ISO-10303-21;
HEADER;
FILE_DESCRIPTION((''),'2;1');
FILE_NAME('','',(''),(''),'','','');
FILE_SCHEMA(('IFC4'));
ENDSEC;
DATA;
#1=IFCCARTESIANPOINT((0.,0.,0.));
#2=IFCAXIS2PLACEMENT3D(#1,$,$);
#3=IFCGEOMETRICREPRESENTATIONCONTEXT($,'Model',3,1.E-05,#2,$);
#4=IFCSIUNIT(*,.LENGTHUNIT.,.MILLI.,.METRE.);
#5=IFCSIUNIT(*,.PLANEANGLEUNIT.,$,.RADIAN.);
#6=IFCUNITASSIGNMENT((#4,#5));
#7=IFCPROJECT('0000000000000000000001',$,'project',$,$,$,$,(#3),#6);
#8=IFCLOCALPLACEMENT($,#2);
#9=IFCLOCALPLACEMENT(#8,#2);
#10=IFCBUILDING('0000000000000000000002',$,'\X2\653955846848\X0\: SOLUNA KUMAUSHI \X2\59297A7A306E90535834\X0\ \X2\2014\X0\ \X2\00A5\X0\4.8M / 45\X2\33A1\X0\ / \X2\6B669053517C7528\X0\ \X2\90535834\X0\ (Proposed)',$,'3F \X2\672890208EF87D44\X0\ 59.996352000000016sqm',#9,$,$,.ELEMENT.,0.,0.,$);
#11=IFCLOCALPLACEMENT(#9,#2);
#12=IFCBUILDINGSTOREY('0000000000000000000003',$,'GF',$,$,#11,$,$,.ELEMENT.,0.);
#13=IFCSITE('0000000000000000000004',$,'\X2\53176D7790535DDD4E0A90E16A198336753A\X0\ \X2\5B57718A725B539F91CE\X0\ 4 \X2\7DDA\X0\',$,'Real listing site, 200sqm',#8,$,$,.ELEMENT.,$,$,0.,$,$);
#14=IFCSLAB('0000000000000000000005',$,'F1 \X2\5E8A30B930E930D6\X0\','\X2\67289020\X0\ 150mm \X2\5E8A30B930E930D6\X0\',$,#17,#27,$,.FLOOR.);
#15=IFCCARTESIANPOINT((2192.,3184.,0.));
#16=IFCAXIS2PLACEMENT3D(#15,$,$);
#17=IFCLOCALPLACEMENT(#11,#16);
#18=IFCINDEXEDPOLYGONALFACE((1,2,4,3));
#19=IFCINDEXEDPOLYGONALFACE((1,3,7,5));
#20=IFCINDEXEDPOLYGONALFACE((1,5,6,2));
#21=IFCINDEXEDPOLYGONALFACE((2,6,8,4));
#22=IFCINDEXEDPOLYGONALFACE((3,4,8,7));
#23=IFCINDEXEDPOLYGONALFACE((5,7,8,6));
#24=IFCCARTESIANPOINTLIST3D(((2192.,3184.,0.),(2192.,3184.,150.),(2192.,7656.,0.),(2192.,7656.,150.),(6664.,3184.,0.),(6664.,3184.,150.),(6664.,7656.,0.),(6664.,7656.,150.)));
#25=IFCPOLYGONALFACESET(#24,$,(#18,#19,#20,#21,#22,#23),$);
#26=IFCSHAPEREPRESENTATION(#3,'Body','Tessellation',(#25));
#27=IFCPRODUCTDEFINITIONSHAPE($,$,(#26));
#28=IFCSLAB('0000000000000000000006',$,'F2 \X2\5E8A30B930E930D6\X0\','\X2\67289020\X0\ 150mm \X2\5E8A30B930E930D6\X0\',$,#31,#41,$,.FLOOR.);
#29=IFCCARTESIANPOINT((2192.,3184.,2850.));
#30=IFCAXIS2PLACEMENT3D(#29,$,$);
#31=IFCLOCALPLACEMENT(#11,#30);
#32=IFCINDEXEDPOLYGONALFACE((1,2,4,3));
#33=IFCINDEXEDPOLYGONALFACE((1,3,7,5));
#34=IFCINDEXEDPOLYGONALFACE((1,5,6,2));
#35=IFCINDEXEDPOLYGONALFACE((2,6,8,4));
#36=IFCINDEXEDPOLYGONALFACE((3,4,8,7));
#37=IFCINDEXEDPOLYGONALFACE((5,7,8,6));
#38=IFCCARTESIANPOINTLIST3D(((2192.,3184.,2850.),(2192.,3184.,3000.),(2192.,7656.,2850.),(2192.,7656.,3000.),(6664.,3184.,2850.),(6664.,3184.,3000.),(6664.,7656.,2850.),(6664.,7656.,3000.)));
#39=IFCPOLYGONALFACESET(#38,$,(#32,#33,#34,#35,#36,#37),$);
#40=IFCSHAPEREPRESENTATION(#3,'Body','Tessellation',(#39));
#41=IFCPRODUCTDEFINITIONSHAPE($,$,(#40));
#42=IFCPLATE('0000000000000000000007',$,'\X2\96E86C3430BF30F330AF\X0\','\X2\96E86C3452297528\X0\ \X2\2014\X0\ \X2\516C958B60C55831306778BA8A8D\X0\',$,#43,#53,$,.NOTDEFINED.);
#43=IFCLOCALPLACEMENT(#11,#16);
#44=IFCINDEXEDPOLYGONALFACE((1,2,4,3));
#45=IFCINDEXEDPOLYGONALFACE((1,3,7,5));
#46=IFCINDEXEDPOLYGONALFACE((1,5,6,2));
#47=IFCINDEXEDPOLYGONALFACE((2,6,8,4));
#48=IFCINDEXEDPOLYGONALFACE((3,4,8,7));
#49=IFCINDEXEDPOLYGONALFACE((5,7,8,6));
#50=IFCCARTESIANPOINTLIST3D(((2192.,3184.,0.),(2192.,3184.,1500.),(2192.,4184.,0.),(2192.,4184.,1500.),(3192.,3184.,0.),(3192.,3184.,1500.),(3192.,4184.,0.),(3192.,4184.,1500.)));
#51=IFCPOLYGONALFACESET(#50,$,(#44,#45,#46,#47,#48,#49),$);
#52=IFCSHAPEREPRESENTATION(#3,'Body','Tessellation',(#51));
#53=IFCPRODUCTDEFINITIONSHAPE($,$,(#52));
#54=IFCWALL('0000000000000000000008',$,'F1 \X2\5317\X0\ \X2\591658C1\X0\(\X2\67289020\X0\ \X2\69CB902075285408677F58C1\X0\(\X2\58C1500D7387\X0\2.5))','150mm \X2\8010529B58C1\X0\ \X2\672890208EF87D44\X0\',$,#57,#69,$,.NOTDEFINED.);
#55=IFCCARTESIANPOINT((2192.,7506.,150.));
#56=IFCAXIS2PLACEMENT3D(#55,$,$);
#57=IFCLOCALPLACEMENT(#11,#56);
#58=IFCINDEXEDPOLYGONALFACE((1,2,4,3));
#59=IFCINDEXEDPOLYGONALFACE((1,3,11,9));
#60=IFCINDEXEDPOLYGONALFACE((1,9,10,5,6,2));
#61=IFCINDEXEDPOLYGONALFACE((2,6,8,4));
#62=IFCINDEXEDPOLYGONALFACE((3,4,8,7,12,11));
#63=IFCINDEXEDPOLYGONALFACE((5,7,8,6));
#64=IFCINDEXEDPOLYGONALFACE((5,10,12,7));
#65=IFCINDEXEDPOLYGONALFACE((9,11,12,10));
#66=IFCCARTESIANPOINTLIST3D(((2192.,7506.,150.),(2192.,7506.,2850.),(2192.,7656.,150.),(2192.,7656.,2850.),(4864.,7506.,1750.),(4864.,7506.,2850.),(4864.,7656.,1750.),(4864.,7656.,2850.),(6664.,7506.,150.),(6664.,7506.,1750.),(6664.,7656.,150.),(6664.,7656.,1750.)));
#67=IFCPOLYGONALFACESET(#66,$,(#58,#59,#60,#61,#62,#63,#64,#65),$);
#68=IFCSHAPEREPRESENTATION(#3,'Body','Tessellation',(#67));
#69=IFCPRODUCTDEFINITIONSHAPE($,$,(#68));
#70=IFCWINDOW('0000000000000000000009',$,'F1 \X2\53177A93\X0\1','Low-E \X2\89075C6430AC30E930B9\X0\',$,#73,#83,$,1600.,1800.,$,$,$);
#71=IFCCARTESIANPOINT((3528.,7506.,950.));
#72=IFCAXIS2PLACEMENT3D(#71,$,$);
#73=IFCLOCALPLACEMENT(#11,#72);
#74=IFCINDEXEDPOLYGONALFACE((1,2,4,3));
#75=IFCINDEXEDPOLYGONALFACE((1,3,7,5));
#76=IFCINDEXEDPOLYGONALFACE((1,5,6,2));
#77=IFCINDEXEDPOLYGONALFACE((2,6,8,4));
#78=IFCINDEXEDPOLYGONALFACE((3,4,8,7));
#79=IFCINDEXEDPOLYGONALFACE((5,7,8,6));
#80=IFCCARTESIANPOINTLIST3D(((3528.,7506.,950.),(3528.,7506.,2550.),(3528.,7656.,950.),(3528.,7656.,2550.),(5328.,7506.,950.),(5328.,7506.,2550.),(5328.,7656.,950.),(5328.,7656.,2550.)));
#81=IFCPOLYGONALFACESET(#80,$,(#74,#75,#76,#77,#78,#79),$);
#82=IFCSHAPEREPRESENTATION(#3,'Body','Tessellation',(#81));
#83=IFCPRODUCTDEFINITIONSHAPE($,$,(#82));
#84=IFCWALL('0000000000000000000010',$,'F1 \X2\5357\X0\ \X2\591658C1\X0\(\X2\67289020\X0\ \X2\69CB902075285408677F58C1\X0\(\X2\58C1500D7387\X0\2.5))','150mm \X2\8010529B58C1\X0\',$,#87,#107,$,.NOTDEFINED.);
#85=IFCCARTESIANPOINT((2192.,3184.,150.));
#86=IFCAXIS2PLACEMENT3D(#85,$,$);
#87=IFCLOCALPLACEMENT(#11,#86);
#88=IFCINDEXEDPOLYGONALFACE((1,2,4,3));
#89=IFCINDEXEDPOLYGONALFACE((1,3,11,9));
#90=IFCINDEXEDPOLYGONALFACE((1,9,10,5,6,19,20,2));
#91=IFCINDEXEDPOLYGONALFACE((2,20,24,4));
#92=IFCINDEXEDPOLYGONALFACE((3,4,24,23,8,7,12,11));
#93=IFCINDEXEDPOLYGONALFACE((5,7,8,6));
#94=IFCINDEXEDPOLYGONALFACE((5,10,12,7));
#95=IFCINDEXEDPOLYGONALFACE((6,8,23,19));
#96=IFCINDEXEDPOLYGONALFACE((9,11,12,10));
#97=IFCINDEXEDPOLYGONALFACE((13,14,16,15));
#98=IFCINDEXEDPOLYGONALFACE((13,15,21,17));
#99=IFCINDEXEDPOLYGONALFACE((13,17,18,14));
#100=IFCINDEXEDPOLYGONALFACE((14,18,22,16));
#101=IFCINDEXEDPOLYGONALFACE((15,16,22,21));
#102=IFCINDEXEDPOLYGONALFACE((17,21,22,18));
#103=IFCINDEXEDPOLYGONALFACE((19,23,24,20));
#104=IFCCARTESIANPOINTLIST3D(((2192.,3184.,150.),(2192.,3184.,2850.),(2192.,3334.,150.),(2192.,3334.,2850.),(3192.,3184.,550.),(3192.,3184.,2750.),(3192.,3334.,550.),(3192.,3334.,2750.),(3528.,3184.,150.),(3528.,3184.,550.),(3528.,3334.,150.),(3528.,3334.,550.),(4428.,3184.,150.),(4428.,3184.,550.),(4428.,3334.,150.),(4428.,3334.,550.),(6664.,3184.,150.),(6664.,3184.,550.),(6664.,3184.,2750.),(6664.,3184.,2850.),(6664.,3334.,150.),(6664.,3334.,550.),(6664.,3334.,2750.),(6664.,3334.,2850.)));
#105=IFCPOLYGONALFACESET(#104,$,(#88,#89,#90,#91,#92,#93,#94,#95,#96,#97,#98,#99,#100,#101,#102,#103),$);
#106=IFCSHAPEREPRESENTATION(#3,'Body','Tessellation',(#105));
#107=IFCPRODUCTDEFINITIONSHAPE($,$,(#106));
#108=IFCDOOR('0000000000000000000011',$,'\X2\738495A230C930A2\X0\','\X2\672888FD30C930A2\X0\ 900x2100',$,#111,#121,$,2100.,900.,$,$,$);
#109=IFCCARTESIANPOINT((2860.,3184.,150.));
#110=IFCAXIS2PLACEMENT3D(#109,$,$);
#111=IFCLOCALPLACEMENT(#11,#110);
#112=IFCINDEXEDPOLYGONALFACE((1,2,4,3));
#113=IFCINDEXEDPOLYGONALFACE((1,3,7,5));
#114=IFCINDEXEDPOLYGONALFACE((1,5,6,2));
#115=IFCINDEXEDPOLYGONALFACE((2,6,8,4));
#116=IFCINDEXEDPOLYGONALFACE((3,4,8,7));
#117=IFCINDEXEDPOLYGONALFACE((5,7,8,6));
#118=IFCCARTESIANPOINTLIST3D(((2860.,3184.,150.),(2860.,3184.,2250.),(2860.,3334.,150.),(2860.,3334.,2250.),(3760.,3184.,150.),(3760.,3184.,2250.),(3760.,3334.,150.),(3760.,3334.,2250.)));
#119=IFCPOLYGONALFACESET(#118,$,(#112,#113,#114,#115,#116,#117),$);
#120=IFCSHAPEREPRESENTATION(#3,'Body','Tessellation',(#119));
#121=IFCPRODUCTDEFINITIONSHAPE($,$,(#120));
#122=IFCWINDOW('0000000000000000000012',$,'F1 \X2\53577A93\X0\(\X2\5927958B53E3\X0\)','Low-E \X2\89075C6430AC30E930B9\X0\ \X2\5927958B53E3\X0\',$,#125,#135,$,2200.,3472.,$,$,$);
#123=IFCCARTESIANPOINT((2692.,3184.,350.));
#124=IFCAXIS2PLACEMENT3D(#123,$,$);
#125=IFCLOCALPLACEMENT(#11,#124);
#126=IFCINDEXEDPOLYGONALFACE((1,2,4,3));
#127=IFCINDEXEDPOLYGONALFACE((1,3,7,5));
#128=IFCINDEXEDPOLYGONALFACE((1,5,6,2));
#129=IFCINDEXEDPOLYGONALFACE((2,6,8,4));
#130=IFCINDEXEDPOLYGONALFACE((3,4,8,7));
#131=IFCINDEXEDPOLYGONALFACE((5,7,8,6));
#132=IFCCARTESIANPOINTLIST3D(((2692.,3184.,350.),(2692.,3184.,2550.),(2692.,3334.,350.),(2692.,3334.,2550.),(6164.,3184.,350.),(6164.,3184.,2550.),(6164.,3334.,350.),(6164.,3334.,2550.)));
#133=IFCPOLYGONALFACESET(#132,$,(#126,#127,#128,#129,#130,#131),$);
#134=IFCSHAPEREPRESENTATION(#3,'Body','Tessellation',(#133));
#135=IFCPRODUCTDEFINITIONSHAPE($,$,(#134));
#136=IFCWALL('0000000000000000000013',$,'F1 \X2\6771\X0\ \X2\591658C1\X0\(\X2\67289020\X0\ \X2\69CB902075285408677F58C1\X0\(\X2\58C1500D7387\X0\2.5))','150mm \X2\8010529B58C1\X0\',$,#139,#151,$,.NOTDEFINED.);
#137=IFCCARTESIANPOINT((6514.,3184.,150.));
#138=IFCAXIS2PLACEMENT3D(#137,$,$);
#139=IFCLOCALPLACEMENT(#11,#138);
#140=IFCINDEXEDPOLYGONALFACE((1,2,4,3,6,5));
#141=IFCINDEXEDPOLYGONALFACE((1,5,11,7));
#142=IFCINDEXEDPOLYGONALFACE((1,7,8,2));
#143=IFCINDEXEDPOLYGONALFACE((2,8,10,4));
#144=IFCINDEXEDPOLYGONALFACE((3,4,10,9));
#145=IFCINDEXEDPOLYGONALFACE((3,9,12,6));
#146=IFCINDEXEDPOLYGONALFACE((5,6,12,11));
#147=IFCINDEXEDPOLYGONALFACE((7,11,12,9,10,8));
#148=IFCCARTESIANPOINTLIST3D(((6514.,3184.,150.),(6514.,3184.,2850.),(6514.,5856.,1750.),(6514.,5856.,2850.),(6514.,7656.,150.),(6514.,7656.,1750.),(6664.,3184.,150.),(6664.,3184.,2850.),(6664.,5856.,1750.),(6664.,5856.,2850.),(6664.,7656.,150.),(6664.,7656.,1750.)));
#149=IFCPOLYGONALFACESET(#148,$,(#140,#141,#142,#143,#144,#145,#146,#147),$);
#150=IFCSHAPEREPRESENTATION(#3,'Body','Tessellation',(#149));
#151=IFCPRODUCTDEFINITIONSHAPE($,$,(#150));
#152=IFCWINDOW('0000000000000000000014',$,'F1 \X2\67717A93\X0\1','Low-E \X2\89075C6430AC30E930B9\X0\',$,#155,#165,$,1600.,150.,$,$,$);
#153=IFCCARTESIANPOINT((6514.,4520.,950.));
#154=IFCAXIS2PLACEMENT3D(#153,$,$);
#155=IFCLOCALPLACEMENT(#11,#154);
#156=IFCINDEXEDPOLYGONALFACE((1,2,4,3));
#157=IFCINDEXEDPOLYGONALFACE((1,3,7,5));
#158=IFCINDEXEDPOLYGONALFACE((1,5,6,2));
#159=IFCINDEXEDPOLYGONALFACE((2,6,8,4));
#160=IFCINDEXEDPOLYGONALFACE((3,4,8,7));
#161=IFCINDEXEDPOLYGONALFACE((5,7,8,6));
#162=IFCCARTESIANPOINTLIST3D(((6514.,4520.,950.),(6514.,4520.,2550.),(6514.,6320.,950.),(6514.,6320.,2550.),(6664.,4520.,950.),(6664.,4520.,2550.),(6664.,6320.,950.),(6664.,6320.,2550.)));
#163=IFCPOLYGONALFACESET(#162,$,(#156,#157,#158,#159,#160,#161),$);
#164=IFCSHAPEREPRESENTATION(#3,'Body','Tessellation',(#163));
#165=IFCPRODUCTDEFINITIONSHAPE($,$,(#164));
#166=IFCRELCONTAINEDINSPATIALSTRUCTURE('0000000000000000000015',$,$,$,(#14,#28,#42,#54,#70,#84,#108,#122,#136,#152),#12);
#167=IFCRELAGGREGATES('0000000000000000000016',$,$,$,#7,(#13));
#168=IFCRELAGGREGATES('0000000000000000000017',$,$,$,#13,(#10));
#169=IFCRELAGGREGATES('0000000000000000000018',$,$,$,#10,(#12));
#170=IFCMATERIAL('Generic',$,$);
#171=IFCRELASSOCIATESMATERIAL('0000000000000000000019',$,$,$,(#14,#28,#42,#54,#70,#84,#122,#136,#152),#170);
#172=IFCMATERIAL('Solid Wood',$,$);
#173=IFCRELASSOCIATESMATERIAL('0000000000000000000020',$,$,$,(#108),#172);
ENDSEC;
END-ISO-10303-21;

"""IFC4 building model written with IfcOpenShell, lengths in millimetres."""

from ifc_helpers import new_model, si_unit, frame, frame_2d, origin, place, context, project, spatial, rectangle, extrude, material, element, fill, save


model = new_model("IFC4")

# Units and contexts
model_context = context("Model", 3, precision=1e-05, world=origin())
ifc_project = project(units=[si_unit("LENGTHUNIT", "METRE", prefix="MILLI"), si_unit("PLANEANGLEUNIT", "RADIAN")], contexts=[model_context])

# Site, building, storey
site_placement = place(None, origin())
site = spatial("IfcSite", under=ifc_project, at=site_placement, Name="北海道川上郡標茶町 字熊牛原野 4 線", ObjectType="Real listing site, 200sqm", CompositionType="ELEMENT", RefElevation=0.0)
building_placement = place(site_placement, origin())
building = spatial("IfcBuilding", under=site, at=building_placement, Name="改善案: SOLUNA KUMAUSHI 天空の道場 — ¥4.8M / 45㎡ / 武道兼用 道場 (Proposed)", ObjectType="3F 木造軸組 59.996352000000016sqm", CompositionType="ELEMENT", ElevationOfRefHeight=0.0, ElevationOfTerrain=0.0)
storey_placement = place(building_placement, origin())
storey = spatial("IfcBuildingStorey", under=building, at=storey_placement, Name="GF", CompositionType="ELEMENT", Elevation=0.0)

# Slabs
ifc_material_1 = material(Name="Generic")
slab_1_placement = place(storey_placement, frame((2192.0, 3184.0, 0.0)))
element("IfcSlab", 1, at=slab_1_placement, inside=storey, material=ifc_material_1, Name="F1 床スラブ", Description="木造 150mm 床スラブ", PredefinedType="FLOOR", context=model_context, shape_type="SweptSolid", body=[
    extrude(rectangle(XDim=4472.0, YDim=4472.0, at=frame_2d((2236.0, 2236.0))), frame((2192.0, 3184.0, 0.0)), (0.0, 0.0, 1.0), 150.0),
])
slab_2_placement = place(storey_placement, frame((2192.0, 3184.0, 2850.0)))
element("IfcSlab", 2, at=slab_2_placement, inside=storey, material=ifc_material_1, Name="F2 床スラブ", Description="木造 150mm 床スラブ", PredefinedType="FLOOR", context=model_context, shape_type="SweptSolid", body=[
    extrude(rectangle(XDim=4472.0, YDim=4472.0, at=frame_2d((2236.0, 2236.0))), frame((2192.0, 3184.0, 2850.0)), (0.0, 0.0, 1.0), 150.0),
])

# Plate
plate_placement = place(storey_placement, frame((2192.0, 3184.0, 0.0)))
element("IfcPlate", 3, at=plate_placement, inside=storey, material=ifc_material_1, Name="雨水タンク", Description="雨水利用 — 公開情報で確認", PredefinedType="NOTDEFINED", context=model_context, shape_type="SweptSolid", body=[
    extrude(rectangle(XDim=1000.0, YDim=1000.0, at=frame_2d((500.0, 500.0))), frame((2192.0, 3184.0, 0.0)), (0.0, 0.0, 1.0), 1500.0),
])

# Wall, opening, window
wall_1_placement = place(storey_placement, frame((2192.0, 7506.0, 150.0)))
wall_1 = element("IfcWall", 4, at=wall_1_placement, inside=storey, material=ifc_material_1, Name="F1 北 外壁(木造 構造用合板壁(壁倍率2.5))", Description="150mm 耐力壁 木造軸組", PredefinedType="NOTDEFINED", context=model_context, shape_type="SweptSolid", body=[
    extrude(rectangle(XDim=4472.0, YDim=150.0, at=frame_2d((2236.0, 75.0))), frame((2192.0, 7506.0, 150.0)), (0.0, 0.0, 1.0), 2700.0),
])
opening_1_placement = place(storey_placement, frame((3528.0, 7506.0, 950.0)))
opening_1 = element("IfcOpeningElement", 5, at=opening_1_placement, cuts=wall_1, PredefinedType="NOTDEFINED", context=model_context, shape_type="SweptSolid", body=[
    extrude(rectangle(XDim=1800.0, YDim=150.0, at=frame_2d((900.0, 75.0))), frame((3528.0, 7506.0, 950.0)), (0.0, 0.0, 1.0), 1600.0),
])
window_1_placement = place(storey_placement, frame((3528.0, 7506.0, 950.0)))
window_1 = element("IfcWindow", 6, at=window_1_placement, inside=storey, material=ifc_material_1, Name="F1 北窓1", Description="Low-E 複層ガラス", OverallHeight=1600.0, OverallWidth=1800.0, context=model_context, shape_type="SweptSolid", body=[
    extrude(rectangle(XDim=1800.0, YDim=150.0, at=frame_2d((900.0, 75.0))), frame((3528.0, 7506.0, 950.0)), (0.0, 0.0, 1.0), 1600.0),
])
fill(opening_1, window_1)

# Wall, openings, door, window
wall_2_placement = place(storey_placement, frame((2192.0, 3184.0, 150.0)))
wall_2 = element("IfcWall", 7, at=wall_2_placement, inside=storey, material=ifc_material_1, Name="F1 南 外壁(木造 構造用合板壁(壁倍率2.5))", Description="150mm 耐力壁", PredefinedType="NOTDEFINED", context=model_context, shape_type="SweptSolid", body=[
    extrude(rectangle(XDim=4472.0, YDim=150.0, at=frame_2d((2236.0, 75.0))), frame((2192.0, 3184.0, 150.0)), (0.0, 0.0, 1.0), 2700.0),
])
opening_2_placement = place(storey_placement, frame((2860.0, 3184.0, 150.0)))
opening_2 = element("IfcOpeningElement", 8, at=opening_2_placement, cuts=wall_2, PredefinedType="NOTDEFINED", context=model_context, shape_type="SweptSolid", body=[
    extrude(rectangle(XDim=900.0, YDim=150.0, at=frame_2d((450.0, 75.0))), frame((2860.0, 3184.0, 150.0)), (0.0, 0.0, 1.0), 2100.0),
])
opening_3_placement = place(storey_placement, frame((2692.0, 3184.0, 350.0)))
opening_3 = element("IfcOpeningElement", 9, at=opening_3_placement, cuts=wall_2, PredefinedType="NOTDEFINED", context=model_context, shape_type="SweptSolid", body=[
    extrude(rectangle(XDim=3472.0, YDim=150.0, at=frame_2d((1736.0, 75.0))), frame((2692.0, 3184.0, 350.0)), (0.0, 0.0, 1.0), 2200.0),
])
ifc_material_2 = material(Name="Solid Wood")
door_placement = place(storey_placement, frame((2860.0, 3184.0, 150.0)))
door = element("IfcDoor", 10, at=door_placement, inside=storey, material=ifc_material_2, Name="玄関ドア", Description="木製ドア 900x2100", OverallHeight=2100.0, OverallWidth=900.0, context=model_context, shape_type="SweptSolid", body=[
    extrude(rectangle(XDim=900.0, YDim=150.0, at=frame_2d((450.0, 75.0))), frame((2860.0, 3184.0, 150.0)), (0.0, 0.0, 1.0), 2100.0),
])
fill(opening_2, door)
window_2_placement = place(storey_placement, frame((2692.0, 3184.0, 350.0)))
window_2 = element("IfcWindow", 11, at=window_2_placement, inside=storey, material=ifc_material_1, Name="F1 南窓(大開口)", Description="Low-E 複層ガラス 大開口", OverallHeight=2200.0, OverallWidth=3472.0, context=model_context, shape_type="SweptSolid", body=[
    extrude(rectangle(XDim=3472.0, YDim=150.0, at=frame_2d((1736.0, 75.0))), frame((2692.0, 3184.0, 350.0)), (0.0, 0.0, 1.0), 2200.0),
])
fill(opening_3, window_2)

# Wall, opening, window
wall_3_placement = place(storey_placement, frame((6514.0, 3184.0, 150.0)))
wall_3 = element("IfcWall", 12, at=wall_3_placement, inside=storey, material=ifc_material_1, Name="F1 東 外壁(木造 構造用合板壁(壁倍率2.5))", Description="150mm 耐力壁", PredefinedType="NOTDEFINED", context=model_context, shape_type="SweptSolid", body=[
    extrude(rectangle(XDim=150.0, YDim=4472.0, at=frame_2d((75.0, 2236.0))), frame((6514.0, 3184.0, 150.0)), (0.0, 0.0, 1.0), 2700.0),
])
opening_4_placement = place(storey_placement, frame((6514.0, 4520.0, 950.0)))
opening_4 = element("IfcOpeningElement", 13, at=opening_4_placement, cuts=wall_3, PredefinedType="NOTDEFINED", context=model_context, shape_type="SweptSolid", body=[
    extrude(rectangle(XDim=150.0, YDim=1800.0, at=frame_2d((75.0, 900.0))), frame((6514.0, 4520.0, 950.0)), (0.0, 0.0, 1.0), 1600.0),
])
window_3_placement = place(storey_placement, frame((6514.0, 4520.0, 950.0)))
window_3 = element("IfcWindow", 14, at=window_3_placement, inside=storey, material=ifc_material_1, Name="F1 東窓1", Description="Low-E 複層ガラス", OverallHeight=1600.0, OverallWidth=150.0, context=model_context, shape_type="SweptSolid", body=[
    extrude(rectangle(XDim=150.0, YDim=1800.0, at=frame_2d((75.0, 900.0))), frame((6514.0, 4520.0, 950.0)), (0.0, 0.0, 1.0), 1600.0),
])
fill(opening_4, window_3)

save(model, "model.ifc")
